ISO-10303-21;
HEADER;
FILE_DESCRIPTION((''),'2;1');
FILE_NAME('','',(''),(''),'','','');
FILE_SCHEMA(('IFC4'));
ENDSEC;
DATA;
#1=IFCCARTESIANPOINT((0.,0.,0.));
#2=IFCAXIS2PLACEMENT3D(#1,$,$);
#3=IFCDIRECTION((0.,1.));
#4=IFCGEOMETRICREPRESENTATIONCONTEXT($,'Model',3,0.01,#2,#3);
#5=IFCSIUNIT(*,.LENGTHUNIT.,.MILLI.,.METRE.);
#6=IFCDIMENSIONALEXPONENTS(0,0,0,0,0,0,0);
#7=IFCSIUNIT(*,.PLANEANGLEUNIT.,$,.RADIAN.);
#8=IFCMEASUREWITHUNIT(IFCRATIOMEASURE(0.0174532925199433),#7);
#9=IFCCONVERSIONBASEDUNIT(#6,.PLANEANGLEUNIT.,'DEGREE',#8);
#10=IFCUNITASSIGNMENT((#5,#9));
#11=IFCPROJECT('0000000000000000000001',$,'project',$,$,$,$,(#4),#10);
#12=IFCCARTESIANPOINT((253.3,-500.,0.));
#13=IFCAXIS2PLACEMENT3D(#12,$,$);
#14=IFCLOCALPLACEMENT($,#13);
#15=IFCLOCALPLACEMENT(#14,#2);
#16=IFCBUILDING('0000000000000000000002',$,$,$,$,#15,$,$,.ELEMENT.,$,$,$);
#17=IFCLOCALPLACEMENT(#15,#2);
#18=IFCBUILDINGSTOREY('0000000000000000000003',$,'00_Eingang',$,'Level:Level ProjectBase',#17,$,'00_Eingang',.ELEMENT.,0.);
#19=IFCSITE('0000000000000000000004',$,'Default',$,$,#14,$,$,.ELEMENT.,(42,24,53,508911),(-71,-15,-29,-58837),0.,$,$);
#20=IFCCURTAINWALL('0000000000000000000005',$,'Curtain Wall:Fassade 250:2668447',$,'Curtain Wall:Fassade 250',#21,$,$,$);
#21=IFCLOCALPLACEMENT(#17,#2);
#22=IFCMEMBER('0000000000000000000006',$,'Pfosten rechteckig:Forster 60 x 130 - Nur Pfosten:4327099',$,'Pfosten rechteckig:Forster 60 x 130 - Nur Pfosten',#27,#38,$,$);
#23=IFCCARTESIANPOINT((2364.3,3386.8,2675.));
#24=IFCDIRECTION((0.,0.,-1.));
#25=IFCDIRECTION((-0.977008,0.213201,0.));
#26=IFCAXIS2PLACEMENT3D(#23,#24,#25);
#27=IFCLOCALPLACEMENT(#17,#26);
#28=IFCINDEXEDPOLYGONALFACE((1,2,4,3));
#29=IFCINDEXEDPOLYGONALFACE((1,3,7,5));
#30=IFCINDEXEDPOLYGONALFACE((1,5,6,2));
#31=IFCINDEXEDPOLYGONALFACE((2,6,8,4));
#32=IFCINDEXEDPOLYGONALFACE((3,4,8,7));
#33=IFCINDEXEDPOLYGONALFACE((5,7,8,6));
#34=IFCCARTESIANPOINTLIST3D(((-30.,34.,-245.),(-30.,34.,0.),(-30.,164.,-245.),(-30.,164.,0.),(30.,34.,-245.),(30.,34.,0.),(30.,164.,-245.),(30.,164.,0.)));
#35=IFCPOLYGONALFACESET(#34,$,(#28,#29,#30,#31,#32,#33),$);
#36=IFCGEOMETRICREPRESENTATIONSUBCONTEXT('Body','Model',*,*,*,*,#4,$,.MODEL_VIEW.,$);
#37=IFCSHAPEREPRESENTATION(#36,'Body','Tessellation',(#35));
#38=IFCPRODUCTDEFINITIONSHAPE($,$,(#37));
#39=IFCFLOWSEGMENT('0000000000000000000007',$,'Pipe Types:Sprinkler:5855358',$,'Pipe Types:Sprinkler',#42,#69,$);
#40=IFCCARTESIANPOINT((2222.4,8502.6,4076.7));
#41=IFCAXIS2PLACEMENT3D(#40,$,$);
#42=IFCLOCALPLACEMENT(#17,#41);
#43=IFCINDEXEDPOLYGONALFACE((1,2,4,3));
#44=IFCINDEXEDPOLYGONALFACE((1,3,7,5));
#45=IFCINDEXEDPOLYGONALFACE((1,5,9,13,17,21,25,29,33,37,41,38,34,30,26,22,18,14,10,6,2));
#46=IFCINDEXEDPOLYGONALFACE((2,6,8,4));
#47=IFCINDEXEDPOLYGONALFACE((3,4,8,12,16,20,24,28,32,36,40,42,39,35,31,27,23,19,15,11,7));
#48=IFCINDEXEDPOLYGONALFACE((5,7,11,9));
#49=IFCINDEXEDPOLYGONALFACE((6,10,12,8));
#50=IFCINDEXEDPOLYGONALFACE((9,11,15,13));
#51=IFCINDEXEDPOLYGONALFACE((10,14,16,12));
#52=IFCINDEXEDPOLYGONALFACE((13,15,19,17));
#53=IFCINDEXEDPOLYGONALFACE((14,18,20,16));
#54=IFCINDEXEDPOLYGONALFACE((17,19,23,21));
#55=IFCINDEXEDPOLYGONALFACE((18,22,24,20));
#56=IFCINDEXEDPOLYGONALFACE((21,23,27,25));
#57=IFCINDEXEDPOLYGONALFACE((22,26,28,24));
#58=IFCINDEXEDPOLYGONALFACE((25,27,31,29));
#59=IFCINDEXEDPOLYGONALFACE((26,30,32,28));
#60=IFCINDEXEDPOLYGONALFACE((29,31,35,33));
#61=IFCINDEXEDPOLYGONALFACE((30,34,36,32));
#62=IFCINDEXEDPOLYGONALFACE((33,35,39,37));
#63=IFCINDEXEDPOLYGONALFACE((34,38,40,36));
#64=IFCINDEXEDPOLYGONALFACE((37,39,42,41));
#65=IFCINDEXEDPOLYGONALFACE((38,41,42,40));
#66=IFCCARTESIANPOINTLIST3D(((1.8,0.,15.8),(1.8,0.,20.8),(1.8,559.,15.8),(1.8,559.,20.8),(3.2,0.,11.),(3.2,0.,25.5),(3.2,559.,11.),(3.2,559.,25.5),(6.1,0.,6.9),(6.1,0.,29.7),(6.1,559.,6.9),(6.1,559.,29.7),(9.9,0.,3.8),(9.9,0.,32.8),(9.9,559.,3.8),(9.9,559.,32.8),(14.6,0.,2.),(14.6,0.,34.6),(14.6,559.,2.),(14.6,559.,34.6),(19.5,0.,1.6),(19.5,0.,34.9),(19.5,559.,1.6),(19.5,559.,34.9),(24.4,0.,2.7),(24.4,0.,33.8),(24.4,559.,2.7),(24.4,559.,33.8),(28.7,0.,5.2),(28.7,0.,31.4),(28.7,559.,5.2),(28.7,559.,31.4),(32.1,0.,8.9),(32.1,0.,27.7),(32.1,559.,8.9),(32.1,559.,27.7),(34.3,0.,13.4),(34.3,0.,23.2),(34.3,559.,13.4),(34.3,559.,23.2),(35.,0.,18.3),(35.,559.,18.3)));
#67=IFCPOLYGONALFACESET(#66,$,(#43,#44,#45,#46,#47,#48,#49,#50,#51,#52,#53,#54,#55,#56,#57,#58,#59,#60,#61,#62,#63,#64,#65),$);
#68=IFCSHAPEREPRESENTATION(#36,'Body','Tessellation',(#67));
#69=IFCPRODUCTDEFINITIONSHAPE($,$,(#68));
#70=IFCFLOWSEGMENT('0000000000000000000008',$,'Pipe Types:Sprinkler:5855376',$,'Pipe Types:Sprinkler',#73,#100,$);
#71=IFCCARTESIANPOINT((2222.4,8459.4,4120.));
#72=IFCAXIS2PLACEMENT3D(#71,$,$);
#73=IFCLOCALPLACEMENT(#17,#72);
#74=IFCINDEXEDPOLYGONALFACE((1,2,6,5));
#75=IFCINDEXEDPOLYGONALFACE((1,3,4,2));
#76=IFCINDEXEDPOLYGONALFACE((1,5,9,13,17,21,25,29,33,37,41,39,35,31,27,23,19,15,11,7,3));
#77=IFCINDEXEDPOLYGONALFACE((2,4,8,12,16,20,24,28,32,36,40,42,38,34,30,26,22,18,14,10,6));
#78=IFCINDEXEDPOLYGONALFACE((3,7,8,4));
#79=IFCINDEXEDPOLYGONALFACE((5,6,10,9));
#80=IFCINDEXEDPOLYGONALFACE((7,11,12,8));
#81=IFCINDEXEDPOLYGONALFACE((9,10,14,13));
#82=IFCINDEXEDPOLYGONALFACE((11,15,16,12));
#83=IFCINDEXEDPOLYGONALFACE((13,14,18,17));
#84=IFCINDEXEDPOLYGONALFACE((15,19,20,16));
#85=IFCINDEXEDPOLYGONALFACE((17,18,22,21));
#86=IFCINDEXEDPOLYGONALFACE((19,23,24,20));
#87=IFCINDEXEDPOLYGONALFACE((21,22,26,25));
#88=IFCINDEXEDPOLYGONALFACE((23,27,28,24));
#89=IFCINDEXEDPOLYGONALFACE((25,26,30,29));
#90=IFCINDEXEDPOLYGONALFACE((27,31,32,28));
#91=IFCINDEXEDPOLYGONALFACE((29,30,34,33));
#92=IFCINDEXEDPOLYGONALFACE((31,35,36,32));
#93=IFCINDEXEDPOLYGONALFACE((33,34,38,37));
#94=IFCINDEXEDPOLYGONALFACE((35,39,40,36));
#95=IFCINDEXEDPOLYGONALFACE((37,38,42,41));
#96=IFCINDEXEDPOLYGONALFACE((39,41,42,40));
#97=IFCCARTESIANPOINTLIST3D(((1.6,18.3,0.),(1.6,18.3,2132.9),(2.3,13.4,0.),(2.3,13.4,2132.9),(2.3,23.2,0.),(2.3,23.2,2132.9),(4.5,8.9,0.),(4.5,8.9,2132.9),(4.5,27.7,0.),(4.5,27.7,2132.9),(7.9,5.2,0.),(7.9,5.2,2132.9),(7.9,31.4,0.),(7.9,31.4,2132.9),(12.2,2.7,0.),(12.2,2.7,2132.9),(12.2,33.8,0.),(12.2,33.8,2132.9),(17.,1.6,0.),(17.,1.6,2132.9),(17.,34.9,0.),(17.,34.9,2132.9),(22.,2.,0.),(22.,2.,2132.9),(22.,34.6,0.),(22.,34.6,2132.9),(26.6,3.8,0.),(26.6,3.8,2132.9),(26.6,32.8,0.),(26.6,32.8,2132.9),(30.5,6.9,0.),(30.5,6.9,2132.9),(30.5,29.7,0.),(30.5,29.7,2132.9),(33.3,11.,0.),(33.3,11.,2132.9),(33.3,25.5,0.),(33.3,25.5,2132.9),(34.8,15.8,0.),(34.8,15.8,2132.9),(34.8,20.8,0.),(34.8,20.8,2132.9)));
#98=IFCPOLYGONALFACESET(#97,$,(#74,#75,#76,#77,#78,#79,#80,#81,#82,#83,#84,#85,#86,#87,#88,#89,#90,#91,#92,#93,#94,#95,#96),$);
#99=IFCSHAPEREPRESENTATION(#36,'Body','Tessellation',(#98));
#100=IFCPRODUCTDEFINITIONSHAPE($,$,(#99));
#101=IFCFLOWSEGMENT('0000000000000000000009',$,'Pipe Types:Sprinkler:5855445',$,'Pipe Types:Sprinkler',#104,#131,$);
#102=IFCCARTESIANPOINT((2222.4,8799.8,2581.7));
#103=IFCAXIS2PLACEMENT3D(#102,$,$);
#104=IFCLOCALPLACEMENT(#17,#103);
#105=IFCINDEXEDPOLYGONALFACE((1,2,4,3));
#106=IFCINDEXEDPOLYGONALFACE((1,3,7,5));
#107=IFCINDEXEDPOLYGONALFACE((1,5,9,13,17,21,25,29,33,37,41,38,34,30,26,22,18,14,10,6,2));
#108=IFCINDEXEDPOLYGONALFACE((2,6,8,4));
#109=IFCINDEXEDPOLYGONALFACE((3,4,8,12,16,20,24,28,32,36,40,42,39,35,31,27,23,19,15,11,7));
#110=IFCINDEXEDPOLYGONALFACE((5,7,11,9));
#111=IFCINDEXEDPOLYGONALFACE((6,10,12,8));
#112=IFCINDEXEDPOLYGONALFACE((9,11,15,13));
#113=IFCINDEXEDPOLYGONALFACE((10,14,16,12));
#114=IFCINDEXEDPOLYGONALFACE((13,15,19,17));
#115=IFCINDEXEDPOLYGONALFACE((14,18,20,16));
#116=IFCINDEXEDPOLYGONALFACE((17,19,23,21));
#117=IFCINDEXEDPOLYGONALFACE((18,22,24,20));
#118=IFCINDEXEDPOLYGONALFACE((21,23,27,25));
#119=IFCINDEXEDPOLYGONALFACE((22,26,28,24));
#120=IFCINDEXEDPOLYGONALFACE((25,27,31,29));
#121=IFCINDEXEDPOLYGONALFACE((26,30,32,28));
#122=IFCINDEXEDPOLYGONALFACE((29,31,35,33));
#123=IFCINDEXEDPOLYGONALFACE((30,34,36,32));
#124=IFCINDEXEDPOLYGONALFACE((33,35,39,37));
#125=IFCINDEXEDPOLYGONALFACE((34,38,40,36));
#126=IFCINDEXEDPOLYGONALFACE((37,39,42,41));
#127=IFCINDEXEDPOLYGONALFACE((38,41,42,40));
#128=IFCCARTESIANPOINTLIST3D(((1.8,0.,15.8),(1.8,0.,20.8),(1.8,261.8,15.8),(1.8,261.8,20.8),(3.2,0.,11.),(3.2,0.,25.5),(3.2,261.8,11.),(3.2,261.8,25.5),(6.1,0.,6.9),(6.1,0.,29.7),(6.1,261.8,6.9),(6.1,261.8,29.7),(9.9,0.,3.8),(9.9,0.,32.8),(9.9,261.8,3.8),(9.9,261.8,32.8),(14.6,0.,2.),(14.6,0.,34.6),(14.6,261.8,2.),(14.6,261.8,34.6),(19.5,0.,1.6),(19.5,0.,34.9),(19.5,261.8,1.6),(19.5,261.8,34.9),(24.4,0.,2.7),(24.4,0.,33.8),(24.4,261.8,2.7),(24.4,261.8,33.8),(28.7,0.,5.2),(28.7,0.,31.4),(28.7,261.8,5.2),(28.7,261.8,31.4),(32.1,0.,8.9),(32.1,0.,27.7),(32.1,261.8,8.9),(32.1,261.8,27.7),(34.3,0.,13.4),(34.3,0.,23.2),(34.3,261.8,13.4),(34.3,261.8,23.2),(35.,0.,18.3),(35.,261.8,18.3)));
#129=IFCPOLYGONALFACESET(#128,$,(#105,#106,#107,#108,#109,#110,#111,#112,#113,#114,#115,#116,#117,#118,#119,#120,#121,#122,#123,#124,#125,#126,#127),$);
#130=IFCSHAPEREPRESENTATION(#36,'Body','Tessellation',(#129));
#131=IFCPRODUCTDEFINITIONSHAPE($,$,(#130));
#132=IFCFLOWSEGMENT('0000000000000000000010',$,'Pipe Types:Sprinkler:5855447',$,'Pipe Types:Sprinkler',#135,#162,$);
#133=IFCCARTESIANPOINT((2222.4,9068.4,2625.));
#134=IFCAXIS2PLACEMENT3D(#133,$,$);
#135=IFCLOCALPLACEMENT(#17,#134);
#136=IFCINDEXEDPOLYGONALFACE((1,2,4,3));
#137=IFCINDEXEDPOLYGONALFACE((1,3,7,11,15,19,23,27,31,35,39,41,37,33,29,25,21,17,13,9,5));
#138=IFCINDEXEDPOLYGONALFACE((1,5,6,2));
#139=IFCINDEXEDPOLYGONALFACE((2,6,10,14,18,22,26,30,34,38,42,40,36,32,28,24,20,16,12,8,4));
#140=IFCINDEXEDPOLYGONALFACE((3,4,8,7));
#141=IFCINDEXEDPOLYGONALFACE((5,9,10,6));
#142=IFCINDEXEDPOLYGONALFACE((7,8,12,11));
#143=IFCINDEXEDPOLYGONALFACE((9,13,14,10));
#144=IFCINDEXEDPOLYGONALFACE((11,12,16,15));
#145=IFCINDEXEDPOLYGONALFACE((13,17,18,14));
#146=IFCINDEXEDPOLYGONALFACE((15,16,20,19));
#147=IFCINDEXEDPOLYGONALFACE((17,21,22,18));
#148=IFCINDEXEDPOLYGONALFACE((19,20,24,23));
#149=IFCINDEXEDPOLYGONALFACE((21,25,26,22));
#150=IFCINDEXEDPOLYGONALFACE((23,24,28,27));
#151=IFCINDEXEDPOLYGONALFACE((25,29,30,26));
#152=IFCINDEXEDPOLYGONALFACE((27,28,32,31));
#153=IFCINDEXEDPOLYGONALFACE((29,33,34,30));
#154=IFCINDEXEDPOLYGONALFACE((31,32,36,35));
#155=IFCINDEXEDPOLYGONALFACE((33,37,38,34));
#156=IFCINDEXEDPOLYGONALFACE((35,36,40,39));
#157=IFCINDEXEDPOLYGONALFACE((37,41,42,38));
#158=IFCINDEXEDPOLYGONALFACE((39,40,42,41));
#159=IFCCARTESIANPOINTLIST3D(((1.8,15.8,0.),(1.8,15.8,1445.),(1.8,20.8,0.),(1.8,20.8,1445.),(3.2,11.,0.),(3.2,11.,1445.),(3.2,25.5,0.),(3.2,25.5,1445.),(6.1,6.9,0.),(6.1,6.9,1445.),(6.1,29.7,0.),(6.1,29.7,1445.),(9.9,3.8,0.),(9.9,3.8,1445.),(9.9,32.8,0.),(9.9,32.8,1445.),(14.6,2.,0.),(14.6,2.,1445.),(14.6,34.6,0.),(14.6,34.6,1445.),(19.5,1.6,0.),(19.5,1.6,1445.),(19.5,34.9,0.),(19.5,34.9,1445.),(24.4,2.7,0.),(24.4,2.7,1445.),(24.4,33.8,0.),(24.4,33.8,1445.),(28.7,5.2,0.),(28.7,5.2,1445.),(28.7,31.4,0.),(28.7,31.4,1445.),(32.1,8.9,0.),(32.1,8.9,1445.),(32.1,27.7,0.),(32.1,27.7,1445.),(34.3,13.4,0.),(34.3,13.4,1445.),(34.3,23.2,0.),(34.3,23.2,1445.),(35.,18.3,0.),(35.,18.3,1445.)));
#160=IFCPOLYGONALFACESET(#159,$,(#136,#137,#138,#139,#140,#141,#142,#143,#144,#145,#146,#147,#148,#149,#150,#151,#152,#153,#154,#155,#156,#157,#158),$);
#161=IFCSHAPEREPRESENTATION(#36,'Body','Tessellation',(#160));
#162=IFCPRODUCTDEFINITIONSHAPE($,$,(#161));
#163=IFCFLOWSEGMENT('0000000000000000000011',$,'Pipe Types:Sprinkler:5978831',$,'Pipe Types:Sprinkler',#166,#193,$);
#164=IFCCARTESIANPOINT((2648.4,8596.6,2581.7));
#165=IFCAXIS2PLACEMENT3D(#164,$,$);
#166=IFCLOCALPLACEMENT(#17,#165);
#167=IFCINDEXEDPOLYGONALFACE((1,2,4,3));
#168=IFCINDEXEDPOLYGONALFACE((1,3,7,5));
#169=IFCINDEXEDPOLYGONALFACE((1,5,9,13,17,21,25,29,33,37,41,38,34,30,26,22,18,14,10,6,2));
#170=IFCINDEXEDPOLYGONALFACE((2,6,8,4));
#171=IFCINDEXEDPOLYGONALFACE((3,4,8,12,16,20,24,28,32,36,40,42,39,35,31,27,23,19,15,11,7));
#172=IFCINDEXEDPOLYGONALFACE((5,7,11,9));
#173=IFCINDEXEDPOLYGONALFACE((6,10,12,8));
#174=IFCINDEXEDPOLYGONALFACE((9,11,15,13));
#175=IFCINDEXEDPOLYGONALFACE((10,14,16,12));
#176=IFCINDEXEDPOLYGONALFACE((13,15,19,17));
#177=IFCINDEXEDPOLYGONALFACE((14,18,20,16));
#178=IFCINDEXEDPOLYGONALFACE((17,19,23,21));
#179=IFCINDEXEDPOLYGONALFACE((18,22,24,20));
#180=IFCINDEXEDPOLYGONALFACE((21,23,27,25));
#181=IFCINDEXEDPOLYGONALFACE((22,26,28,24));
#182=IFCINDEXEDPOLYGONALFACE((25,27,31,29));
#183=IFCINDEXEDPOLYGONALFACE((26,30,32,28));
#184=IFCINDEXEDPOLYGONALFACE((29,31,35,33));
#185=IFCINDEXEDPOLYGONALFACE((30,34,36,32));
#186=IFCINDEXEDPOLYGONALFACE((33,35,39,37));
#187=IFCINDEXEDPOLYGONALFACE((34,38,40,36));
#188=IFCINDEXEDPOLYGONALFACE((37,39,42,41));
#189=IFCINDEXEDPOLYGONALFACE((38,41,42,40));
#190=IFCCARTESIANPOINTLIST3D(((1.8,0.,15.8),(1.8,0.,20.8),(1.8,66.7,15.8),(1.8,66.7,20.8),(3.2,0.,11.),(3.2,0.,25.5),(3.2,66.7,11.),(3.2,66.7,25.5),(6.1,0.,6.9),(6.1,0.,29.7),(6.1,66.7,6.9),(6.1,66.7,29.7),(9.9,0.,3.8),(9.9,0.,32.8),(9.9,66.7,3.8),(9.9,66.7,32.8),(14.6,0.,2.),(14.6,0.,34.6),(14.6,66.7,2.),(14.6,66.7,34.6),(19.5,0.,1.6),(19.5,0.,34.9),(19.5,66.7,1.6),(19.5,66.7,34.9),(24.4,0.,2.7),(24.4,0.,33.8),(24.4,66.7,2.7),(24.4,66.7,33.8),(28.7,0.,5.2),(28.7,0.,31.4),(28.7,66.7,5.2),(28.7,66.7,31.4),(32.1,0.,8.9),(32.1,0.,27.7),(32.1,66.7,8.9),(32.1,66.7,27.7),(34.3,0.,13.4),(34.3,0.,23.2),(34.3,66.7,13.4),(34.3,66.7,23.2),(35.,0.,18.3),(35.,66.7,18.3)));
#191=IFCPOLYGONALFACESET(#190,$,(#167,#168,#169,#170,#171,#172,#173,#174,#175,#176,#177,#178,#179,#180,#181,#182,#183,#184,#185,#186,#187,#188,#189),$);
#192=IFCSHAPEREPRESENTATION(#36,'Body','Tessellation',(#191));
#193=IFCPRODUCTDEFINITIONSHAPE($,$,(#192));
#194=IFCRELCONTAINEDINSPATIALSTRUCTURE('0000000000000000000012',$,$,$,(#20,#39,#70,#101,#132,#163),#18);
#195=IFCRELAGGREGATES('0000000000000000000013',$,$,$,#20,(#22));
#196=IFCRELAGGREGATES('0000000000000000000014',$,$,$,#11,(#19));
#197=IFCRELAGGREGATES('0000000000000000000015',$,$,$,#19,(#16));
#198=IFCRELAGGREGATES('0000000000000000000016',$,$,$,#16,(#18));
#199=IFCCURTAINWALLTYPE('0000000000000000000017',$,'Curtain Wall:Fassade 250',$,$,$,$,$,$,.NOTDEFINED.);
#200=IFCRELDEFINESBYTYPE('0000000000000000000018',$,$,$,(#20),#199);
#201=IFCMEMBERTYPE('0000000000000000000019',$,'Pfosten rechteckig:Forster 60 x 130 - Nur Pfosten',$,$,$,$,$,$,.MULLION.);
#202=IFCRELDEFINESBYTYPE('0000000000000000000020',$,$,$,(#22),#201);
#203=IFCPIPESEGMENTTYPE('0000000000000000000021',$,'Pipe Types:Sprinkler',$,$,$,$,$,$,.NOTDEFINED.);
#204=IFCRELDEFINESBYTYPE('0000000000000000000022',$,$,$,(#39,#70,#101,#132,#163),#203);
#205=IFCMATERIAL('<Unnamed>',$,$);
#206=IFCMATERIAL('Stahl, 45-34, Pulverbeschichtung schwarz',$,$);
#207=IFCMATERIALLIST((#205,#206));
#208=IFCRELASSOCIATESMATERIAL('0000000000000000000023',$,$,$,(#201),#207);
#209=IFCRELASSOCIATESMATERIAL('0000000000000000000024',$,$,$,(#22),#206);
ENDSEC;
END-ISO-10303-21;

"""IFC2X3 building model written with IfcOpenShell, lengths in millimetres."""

from ifc_helpers import new_model, entity, si_unit, converted_unit, direction, frame, origin, origin_2d_with_axis, place, context, subcontext, project, spatial, rectangle, circle, extrude, source, transform, mapped, material, material_list, type_object, type_shapes, element, aggregate, save


model = new_model("IFC2X3")

# Units and contexts
model_context = context("Model", 3, precision=0.01, world=origin(), true_north=direction((0.0, 1.0)))
body_context = subcontext(model_context, "Body", "Model", "MODEL_VIEW")
ifc_project = project(units=[si_unit("LENGTHUNIT", "METRE", prefix="MILLI"), converted_unit("PLANEANGLEUNIT", "DEGREE", entity("IfcRatioMeasure", 0.0174532925199433), si_unit("PLANEANGLEUNIT", "RADIAN"), dimensions=[0, 0, 0, 0, 0, 0, 0])], contexts=[model_context])

# Site, building, storey
site_placement = place(None, frame((253.3, -500.0, 0.0)))
site = spatial("IfcSite", under=ifc_project, at=site_placement, Name="Default", CompositionType="ELEMENT", RefLatitude=(42, 24, 53, 508911), RefLongitude=(-71, -15, -29, -58837), RefElevation=0.0)
building_placement = place(site_placement, origin())
building = spatial("IfcBuilding", under=site, at=building_placement, CompositionType="ELEMENT")
storey_placement = place(building_placement, origin())
storey = spatial("IfcBuildingStorey", under=building, at=storey_placement, Name="00_Eingang", ObjectType="Level:Level ProjectBase", LongName="00_Eingang", CompositionType="ELEMENT", Elevation=0.0)

# Curtain wall, member
curtain_wall_type = type_object("IfcCurtainWallType", Name="Curtain Wall:Fassade 250", PredefinedType="NOTDEFINED")
curtain_wall_placement = place(storey_placement, origin())
curtain_wall = element("IfcCurtainWall", 1, at=curtain_wall_placement, inside=storey, type_object=curtain_wall_type, Name="Curtain Wall:Fassade 250:2668447", ObjectType="Curtain Wall:Fassade 250")
ifc_material_1 = material(Name="Stahl, 45-34, Pulverbeschichtung schwarz")
ifc_material_2 = material(Name="<Unnamed>")
ifc_material_list_1 = material_list([ifc_material_2, ifc_material_1])
member_type_1 = type_object("IfcMemberType", Name="Pfosten rechteckig:Forster 60 x 130 - Nur Pfosten", PredefinedType="MULLION", material=ifc_material_list_1)
shared_shape_1 = source(origin(), body_context, "Body", "SweptSolid", [
    extrude(rectangle(XDim=130.0, YDim=60.0, at=origin_2d_with_axis()), frame((0.0, 99.0, -245.0), z_axis=(0.0, 0.0, 1.0), x_axis=(0.0, -1.0, 0.0)), (0.0, 0.0, 1.0), 245.0),
])
type_shapes(member_type_1, [shared_shape_1])
member_1_placement = place(storey_placement, frame((2364.3, 3386.8, 2675.0), z_axis=(0.0, 0.0, -1.0), x_axis=(-0.977008, 0.213201, 0.0)))
member_1 = element("IfcMember", 2, at=member_1_placement, type_object=member_type_1, material=ifc_material_1, Name="Pfosten rechteckig:Forster 60 x 130 - Nur Pfosten:4327099", ObjectType="Pfosten rechteckig:Forster 60 x 130 - Nur Pfosten", context=body_context, shape_type="MappedRepresentation", body=[
    mapped(shared_shape_1, transform((0.0, 0.0, 0.0), scale=1.0)),
])
aggregate(curtain_wall, [member_1])

# Flow segments
pipe_segment_type_1 = type_object("IfcPipeSegmentType", Name="Pipe Types:Sprinkler", PredefinedType="NOTDEFINED")
flow_segment_1_placement = place(storey_placement, frame((2222.4, 8502.6, 4076.7)))
element("IfcFlowSegment", 3, at=flow_segment_1_placement, inside=storey, type_object=pipe_segment_type_1, Name="Pipe Types:Sprinkler:5855358", ObjectType="Pipe Types:Sprinkler", context=body_context, shape_type="SweptSolid", body=[
    extrude(circle(Radius=16.7, at=origin_2d_with_axis()), frame((18.3, 0.0, 18.3), z_axis=(0.0, 1.0, 0.0), x_axis=(1.0, 0.0, 0.0)), (0.0, 0.0, 1.0), 559.0),
])
flow_segment_2_placement = place(storey_placement, frame((2222.4, 8459.4, 4120.0)))
element("IfcFlowSegment", 4, at=flow_segment_2_placement, inside=storey, type_object=pipe_segment_type_1, Name="Pipe Types:Sprinkler:5855376", ObjectType="Pipe Types:Sprinkler", context=body_context, shape_type="SweptSolid", body=[
    extrude(circle(Radius=16.7, at=origin_2d_with_axis()), frame((18.3, 18.3, 0.0), z_axis=(0.0, 0.0, 1.0), x_axis=(-1.0, 0.0, 0.0)), (0.0, 0.0, 1.0), 2132.9),
])
flow_segment_3_placement = place(storey_placement, frame((2222.4, 8799.8, 2581.7)))
element("IfcFlowSegment", 5, at=flow_segment_3_placement, inside=storey, type_object=pipe_segment_type_1, Name="Pipe Types:Sprinkler:5855445", ObjectType="Pipe Types:Sprinkler", context=body_context, shape_type="SweptSolid", body=[
    extrude(circle(Radius=16.7, at=origin_2d_with_axis()), frame((18.3, 0.0, 18.3), z_axis=(0.0, 1.0, 0.0), x_axis=(1.0, 0.0, 0.0)), (0.0, 0.0, 1.0), 261.8),
])
flow_segment_4_placement = place(storey_placement, frame((2222.4, 9068.4, 2625.0)))
element("IfcFlowSegment", 6, at=flow_segment_4_placement, inside=storey, type_object=pipe_segment_type_1, Name="Pipe Types:Sprinkler:5855447", ObjectType="Pipe Types:Sprinkler", context=body_context, shape_type="SweptSolid", body=[
    extrude(circle(Radius=16.7, at=origin_2d_with_axis()), frame((18.3, 18.3, 0.0)), (0.0, 0.0, 1.0), 1445.0),
])
flow_segment_5_placement = place(storey_placement, frame((2648.4, 8596.6, 2581.7)))
element("IfcFlowSegment", 7, at=flow_segment_5_placement, inside=storey, type_object=pipe_segment_type_1, Name="Pipe Types:Sprinkler:5978831", ObjectType="Pipe Types:Sprinkler", context=body_context, shape_type="SweptSolid", body=[
    extrude(circle(Radius=16.7, at=origin_2d_with_axis()), frame((18.3, 0.0, 18.3), z_axis=(0.0, 1.0, 0.0), x_axis=(1.0, 0.0, 0.0)), (0.0, 0.0, 1.0), 66.7),
])

save(model, "model.ifc")
